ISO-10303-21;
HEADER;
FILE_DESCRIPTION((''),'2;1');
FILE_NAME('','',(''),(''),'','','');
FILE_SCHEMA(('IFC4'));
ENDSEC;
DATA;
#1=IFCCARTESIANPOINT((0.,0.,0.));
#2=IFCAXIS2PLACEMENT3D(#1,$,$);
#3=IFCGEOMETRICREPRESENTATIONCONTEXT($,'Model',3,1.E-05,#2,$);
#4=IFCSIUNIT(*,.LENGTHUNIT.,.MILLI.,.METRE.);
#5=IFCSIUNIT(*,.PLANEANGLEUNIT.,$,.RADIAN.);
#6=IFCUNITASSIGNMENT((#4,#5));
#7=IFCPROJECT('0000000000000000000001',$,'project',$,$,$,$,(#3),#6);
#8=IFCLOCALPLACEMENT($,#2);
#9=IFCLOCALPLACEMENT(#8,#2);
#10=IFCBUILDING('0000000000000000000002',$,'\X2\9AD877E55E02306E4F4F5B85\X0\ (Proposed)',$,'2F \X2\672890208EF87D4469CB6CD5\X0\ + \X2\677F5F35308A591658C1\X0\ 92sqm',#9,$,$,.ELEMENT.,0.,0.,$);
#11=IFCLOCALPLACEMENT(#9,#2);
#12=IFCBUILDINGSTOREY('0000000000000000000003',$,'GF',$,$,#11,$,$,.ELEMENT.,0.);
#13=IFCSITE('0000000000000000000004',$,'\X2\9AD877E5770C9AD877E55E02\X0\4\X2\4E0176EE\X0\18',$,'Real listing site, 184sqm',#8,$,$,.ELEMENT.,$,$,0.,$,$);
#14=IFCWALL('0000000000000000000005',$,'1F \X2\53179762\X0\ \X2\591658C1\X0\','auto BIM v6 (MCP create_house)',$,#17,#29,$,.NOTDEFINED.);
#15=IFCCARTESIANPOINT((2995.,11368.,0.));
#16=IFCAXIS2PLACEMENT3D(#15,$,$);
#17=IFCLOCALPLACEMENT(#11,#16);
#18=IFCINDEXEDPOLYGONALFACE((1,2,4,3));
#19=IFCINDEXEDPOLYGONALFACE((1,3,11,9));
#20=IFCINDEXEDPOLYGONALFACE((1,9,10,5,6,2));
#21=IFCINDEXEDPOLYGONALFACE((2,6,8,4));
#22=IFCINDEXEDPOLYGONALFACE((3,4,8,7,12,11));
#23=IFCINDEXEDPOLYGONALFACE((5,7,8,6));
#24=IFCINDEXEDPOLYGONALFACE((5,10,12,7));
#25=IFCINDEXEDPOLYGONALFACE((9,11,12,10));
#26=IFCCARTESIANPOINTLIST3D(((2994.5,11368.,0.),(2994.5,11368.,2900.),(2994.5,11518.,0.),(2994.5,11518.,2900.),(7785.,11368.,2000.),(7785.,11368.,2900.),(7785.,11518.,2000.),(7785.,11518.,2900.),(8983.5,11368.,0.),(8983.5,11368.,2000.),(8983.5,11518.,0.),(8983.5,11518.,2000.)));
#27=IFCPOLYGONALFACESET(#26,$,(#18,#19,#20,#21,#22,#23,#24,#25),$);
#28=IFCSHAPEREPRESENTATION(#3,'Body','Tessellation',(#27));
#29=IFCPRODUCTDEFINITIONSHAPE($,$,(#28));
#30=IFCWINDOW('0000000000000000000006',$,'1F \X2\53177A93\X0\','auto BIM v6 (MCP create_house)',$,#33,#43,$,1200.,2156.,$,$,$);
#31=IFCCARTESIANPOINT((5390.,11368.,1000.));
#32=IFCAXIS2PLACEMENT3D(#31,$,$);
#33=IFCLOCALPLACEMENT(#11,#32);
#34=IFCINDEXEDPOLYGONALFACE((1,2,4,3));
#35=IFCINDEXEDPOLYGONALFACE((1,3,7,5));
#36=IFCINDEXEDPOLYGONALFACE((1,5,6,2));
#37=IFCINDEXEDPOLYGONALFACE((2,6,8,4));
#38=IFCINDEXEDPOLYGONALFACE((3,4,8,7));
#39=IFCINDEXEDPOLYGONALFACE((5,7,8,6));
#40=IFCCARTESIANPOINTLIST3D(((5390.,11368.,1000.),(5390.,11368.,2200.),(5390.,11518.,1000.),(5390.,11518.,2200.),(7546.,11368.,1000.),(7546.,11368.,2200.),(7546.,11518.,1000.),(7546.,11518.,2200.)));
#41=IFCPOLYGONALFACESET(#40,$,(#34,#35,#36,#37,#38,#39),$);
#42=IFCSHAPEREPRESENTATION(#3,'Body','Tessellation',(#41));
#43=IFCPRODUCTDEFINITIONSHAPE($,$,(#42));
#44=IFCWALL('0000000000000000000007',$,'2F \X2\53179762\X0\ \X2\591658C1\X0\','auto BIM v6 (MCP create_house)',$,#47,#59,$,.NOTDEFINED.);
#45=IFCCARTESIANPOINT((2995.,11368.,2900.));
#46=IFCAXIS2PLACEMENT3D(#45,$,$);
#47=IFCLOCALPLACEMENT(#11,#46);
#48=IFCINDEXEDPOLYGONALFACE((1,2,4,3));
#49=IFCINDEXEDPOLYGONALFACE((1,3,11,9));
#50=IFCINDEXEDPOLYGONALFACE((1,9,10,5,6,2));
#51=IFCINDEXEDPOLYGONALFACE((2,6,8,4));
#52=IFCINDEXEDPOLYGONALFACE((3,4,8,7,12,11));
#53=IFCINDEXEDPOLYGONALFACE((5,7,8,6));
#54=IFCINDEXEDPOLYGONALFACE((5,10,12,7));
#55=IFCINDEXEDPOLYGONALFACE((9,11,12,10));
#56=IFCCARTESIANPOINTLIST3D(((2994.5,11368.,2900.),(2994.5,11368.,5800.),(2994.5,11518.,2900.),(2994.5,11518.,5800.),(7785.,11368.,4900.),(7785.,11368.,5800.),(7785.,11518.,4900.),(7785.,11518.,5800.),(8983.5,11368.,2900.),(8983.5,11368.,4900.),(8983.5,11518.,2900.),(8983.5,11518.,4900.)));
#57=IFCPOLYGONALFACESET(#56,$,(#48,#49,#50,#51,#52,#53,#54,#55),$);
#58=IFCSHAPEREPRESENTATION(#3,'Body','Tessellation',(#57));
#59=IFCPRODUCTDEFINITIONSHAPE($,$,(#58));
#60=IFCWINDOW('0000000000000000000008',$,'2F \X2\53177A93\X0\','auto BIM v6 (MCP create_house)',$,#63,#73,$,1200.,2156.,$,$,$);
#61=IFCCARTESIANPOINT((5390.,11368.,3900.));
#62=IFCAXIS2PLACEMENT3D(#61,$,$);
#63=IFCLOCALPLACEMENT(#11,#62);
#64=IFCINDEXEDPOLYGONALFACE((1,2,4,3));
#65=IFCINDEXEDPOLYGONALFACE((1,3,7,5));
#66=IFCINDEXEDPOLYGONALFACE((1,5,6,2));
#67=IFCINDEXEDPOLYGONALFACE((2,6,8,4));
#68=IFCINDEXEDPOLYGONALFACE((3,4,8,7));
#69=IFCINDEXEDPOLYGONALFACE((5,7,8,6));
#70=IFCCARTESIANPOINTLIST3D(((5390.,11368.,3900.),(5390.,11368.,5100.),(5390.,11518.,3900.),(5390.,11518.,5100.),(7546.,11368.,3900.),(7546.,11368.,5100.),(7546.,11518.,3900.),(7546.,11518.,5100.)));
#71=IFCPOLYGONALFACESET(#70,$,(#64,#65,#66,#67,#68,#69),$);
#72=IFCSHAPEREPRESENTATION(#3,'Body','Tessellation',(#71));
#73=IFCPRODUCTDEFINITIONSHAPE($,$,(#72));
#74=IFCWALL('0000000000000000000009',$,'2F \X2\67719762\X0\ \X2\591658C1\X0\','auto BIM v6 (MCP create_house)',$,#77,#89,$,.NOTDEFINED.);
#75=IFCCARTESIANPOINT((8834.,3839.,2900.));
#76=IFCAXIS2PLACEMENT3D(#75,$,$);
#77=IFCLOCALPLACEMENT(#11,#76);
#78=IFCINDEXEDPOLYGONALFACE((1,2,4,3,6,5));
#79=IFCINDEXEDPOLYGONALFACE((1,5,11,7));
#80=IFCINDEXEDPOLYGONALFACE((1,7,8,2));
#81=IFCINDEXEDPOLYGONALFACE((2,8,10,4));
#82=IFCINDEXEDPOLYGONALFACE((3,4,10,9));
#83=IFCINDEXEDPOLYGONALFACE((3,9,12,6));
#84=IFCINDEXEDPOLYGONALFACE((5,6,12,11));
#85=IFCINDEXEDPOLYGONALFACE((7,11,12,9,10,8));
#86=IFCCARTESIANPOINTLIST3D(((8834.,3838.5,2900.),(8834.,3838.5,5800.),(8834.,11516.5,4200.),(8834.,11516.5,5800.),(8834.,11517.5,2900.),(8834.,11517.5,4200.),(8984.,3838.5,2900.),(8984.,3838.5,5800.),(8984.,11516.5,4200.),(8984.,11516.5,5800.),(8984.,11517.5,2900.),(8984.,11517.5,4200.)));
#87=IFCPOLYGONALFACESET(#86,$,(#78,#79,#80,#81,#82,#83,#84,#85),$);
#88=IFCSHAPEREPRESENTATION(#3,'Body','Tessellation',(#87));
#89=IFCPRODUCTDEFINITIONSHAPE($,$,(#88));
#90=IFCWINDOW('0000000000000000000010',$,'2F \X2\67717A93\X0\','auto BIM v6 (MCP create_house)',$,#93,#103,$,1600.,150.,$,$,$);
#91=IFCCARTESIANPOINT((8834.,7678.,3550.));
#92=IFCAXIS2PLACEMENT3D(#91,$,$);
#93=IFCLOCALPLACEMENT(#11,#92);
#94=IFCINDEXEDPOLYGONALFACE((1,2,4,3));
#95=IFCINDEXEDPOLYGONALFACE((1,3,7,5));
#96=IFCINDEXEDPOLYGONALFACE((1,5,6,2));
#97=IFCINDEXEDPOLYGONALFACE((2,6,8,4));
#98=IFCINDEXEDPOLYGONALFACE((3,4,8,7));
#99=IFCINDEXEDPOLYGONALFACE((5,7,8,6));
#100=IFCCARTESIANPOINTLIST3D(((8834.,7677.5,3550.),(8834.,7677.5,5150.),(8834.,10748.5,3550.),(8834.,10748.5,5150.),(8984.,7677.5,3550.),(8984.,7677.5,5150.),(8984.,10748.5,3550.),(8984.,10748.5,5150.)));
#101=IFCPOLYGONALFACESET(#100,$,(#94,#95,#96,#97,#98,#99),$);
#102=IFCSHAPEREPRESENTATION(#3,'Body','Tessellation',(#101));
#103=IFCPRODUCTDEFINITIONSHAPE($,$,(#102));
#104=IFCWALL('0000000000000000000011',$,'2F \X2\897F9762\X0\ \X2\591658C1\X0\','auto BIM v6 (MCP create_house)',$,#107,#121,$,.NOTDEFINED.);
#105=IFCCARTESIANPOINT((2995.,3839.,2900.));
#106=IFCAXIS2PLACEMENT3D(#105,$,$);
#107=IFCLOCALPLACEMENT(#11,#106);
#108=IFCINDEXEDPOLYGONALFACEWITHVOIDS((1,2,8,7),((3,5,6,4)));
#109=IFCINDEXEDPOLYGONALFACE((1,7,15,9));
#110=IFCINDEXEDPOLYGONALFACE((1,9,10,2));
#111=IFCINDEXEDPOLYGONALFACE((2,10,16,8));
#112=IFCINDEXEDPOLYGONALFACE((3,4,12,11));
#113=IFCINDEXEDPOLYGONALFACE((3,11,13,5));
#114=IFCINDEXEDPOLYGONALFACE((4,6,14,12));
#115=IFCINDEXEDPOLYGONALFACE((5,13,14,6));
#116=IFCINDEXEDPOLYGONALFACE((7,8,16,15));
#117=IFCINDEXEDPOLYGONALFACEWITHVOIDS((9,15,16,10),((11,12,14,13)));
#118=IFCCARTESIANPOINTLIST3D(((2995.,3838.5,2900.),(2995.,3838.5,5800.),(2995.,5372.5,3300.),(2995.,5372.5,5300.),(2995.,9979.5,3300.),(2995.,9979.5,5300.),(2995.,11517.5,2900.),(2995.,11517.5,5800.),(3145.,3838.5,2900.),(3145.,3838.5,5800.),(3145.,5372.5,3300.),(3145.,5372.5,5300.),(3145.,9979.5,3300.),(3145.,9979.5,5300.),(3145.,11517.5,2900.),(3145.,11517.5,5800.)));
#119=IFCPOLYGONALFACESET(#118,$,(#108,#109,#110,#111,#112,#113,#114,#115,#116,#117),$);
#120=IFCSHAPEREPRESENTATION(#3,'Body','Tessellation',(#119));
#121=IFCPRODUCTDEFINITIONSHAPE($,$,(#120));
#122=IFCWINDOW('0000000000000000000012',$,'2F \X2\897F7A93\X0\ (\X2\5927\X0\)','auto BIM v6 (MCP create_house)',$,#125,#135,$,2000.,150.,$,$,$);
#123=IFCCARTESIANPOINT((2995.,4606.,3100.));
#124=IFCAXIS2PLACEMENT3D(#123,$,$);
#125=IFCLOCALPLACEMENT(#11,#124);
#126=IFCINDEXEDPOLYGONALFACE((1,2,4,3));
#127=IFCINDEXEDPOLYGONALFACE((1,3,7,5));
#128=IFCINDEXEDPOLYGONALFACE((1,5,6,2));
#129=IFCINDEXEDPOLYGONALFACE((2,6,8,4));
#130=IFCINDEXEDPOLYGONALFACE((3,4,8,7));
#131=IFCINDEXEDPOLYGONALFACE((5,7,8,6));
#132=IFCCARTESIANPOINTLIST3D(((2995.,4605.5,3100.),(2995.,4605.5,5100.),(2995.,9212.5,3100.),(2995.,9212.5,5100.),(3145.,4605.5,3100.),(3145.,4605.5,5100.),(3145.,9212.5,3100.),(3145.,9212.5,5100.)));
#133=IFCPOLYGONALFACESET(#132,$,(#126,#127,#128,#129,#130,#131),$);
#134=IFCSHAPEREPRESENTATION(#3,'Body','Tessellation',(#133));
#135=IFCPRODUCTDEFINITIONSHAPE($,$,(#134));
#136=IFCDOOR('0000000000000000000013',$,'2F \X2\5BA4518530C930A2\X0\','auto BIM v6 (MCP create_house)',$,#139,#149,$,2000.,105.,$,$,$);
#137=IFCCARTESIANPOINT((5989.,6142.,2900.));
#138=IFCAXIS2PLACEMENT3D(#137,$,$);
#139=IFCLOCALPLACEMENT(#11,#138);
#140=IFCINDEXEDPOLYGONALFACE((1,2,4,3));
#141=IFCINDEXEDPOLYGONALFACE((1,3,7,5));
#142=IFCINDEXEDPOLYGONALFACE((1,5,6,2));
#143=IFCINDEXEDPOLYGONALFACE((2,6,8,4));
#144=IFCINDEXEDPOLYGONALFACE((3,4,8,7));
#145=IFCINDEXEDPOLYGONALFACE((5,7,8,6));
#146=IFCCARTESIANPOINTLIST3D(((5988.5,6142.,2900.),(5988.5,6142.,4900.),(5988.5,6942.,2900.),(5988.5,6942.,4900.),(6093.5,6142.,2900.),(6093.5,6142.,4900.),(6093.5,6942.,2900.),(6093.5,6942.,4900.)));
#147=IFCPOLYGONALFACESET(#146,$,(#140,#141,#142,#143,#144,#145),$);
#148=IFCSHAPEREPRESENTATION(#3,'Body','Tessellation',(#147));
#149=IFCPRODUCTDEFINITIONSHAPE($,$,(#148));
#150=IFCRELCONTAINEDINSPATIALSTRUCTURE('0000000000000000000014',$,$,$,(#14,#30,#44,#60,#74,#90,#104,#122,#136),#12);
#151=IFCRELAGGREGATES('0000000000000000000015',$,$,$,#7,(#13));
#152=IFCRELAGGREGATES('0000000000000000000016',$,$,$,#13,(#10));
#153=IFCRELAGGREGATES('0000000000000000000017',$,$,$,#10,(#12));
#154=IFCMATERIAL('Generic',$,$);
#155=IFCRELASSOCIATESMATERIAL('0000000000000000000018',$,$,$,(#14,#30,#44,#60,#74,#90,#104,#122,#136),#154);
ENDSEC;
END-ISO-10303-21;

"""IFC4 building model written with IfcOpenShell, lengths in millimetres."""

from ifc_helpers import new_model, si_unit, frame, frame_2d, origin, place, context, project, spatial, rectangle, extrude, material, element, fill, save


model = new_model("IFC4")

# Units and contexts
model_context = context("Model", 3, precision=1e-05, world=origin())
ifc_project = project(units=[si_unit("LENGTHUNIT", "METRE", prefix="MILLI"), si_unit("PLANEANGLEUNIT", "RADIAN")], contexts=[model_context])

# Site, building, storey
site_placement = place(None, origin())
site = spatial("IfcSite", under=ifc_project, at=site_placement, Name="高知県高知市4丁目18", ObjectType="Real listing site, 184sqm", CompositionType="ELEMENT", RefElevation=0.0)
building_placement = place(site_placement, origin())
building = spatial("IfcBuilding", under=site, at=building_placement, Name="高知市の住宅 (Proposed)", ObjectType="2F 木造軸組構法 + 板張り外壁 92sqm", CompositionType="ELEMENT", ElevationOfRefHeight=0.0, ElevationOfTerrain=0.0)
storey_placement = place(building_placement, origin())
storey = spatial("IfcBuildingStorey", under=building, at=storey_placement, Name="GF", CompositionType="ELEMENT", Elevation=0.0)

# Wall, opening, window
ifc_material = material(Name="Generic")
wall_1_placement = place(storey_placement, frame((2995.0, 11368.0, 0.0)))
wall_1 = element("IfcWall", 1, at=wall_1_placement, inside=storey, material=ifc_material, Name="1F 北面 外壁", Description="auto BIM v6 (MCP create_house)", PredefinedType="NOTDEFINED", context=model_context, shape_type="SweptSolid", body=[
    extrude(rectangle(XDim=5989.0, YDim=150.0, at=frame_2d((2994.0, 75.0))), frame((2995.0, 11368.0, 0.0)), (0.0, 0.0, 1.0), 2900.0),
])
opening_1_placement = place(storey_placement, frame((5390.0, 11368.0, 1000.0)))
opening_1 = element("IfcOpeningElement", 2, at=opening_1_placement, cuts=wall_1, PredefinedType="NOTDEFINED", context=model_context, shape_type="SweptSolid", body=[
    extrude(rectangle(XDim=2156.0, YDim=150.0, at=frame_2d((1078.0, 75.0))), frame((5390.0, 11368.0, 1000.0)), (0.0, 0.0, 1.0), 1200.0),
])
window_1_placement = place(storey_placement, frame((5390.0, 11368.0, 1000.0)))
window_1 = element("IfcWindow", 3, at=window_1_placement, inside=storey, material=ifc_material, Name="1F 北窓", Description="auto BIM v6 (MCP create_house)", OverallHeight=1200.0, OverallWidth=2156.0, context=model_context, shape_type="SweptSolid", body=[
    extrude(rectangle(XDim=2156.0, YDim=150.0, at=frame_2d((1078.0, 75.0))), frame((5390.0, 11368.0, 1000.0)), (0.0, 0.0, 1.0), 1200.0),
])
fill(opening_1, window_1)

# Walls, openings, windows
wall_2_placement = place(storey_placement, frame((2995.0, 11368.0, 2900.0)))
wall_2 = element("IfcWall", 4, at=wall_2_placement, inside=storey, material=ifc_material, Name="2F 北面 外壁", Description="auto BIM v6 (MCP create_house)", PredefinedType="NOTDEFINED", context=model_context, shape_type="SweptSolid", body=[
    extrude(rectangle(XDim=5989.0, YDim=150.0, at=frame_2d((2994.0, 75.0))), frame((2995.0, 11368.0, 2900.0)), (0.0, 0.0, 1.0), 2900.0),
])
opening_2_placement = place(storey_placement, frame((5390.0, 11368.0, 3900.0)))
opening_2 = element("IfcOpeningElement", 5, at=opening_2_placement, cuts=wall_2, PredefinedType="NOTDEFINED", context=model_context, shape_type="SweptSolid", body=[
    extrude(rectangle(XDim=2156.0, YDim=150.0, at=frame_2d((1078.0, 75.0))), frame((5390.0, 11368.0, 3900.0)), (0.0, 0.0, 1.0), 1200.0),
])
window_2_placement = place(storey_placement, frame((5390.0, 11368.0, 3900.0)))
window_2 = element("IfcWindow", 6, at=window_2_placement, inside=storey, material=ifc_material, Name="2F 北窓", Description="auto BIM v6 (MCP create_house)", OverallHeight=1200.0, OverallWidth=2156.0, context=model_context, shape_type="SweptSolid", body=[
    extrude(rectangle(XDim=2156.0, YDim=150.0, at=frame_2d((1078.0, 75.0))), frame((5390.0, 11368.0, 3900.0)), (0.0, 0.0, 1.0), 1200.0),
])
fill(opening_2, window_2)
wall_3_placement = place(storey_placement, frame((8834.0, 3839.0, 2900.0)))
wall_3 = element("IfcWall", 7, at=wall_3_placement, inside=storey, material=ifc_material, Name="2F 東面 外壁", Description="auto BIM v6 (MCP create_house)", PredefinedType="NOTDEFINED", context=model_context, shape_type="SweptSolid", body=[
    extrude(rectangle(XDim=150.0, YDim=7679.0, at=frame_2d((75.0, 3839.0))), frame((8834.0, 3839.0, 2900.0)), (0.0, 0.0, 1.0), 2900.0),
])
opening_3_placement = place(storey_placement, frame((8834.0, 7678.0, 3550.0)))
opening_3 = element("IfcOpeningElement", 8, at=opening_3_placement, cuts=wall_3, PredefinedType="NOTDEFINED", context=model_context, shape_type="SweptSolid", body=[
    extrude(rectangle(XDim=150.0, YDim=3071.0, at=frame_2d((75.0, 1535.0))), frame((8834.0, 7678.0, 3550.0)), (0.0, 0.0, 1.0), 1600.0),
])
window_3_placement = place(storey_placement, frame((8834.0, 7678.0, 3550.0)))
window_3 = element("IfcWindow", 9, at=window_3_placement, inside=storey, material=ifc_material, Name="2F 東窓", Description="auto BIM v6 (MCP create_house)", OverallHeight=1600.0, OverallWidth=150.0, context=model_context, shape_type="SweptSolid", body=[
    extrude(rectangle(XDim=150.0, YDim=3071.0, at=frame_2d((75.0, 1535.0))), frame((8834.0, 7678.0, 3550.0)), (0.0, 0.0, 1.0), 1600.0),
])
fill(opening_3, window_3)
wall_4_placement = place(storey_placement, frame((2995.0, 3839.0, 2900.0)))
wall_4 = element("IfcWall", 10, at=wall_4_placement, inside=storey, material=ifc_material, Name="2F 西面 外壁", Description="auto BIM v6 (MCP create_house)", PredefinedType="NOTDEFINED", context=model_context, shape_type="SweptSolid", body=[
    extrude(rectangle(XDim=150.0, YDim=7679.0, at=frame_2d((75.0, 3839.0))), frame((2995.0, 3839.0, 2900.0)), (0.0, 0.0, 1.0), 2900.0),
])
opening_4_placement = place(storey_placement, frame((2995.0, 4606.0, 3100.0)))
opening_4 = element("IfcOpeningElement", 11, at=opening_4_placement, cuts=wall_4, PredefinedType="NOTDEFINED", context=model_context, shape_type="SweptSolid", body=[
    extrude(rectangle(XDim=150.0, YDim=4607.0, at=frame_2d((75.0, 2303.0))), frame((2995.0, 4606.0, 3100.0)), (0.0, 0.0, 1.0), 2000.0),
])
window_4_placement = place(storey_placement, frame((2995.0, 4606.0, 3100.0)))
window_4 = element("IfcWindow", 12, at=window_4_placement, inside=storey, material=ifc_material, Name="2F 西窓 (大)", Description="auto BIM v6 (MCP create_house)", OverallHeight=2000.0, OverallWidth=150.0, context=model_context, shape_type="SweptSolid", body=[
    extrude(rectangle(XDim=150.0, YDim=4607.0, at=frame_2d((75.0, 2303.0))), frame((2995.0, 4606.0, 3100.0)), (0.0, 0.0, 1.0), 2000.0),
])
fill(opening_4, window_4)

# Door
door_placement = place(storey_placement, frame((5989.0, 6142.0, 2900.0)))
element("IfcDoor", 13, at=door_placement, inside=storey, material=ifc_material, Name="2F 室内ドア", Description="auto BIM v6 (MCP create_house)", OverallHeight=2000.0, OverallWidth=105.0, context=model_context, shape_type="SweptSolid", body=[
    extrude(rectangle(XDim=105.0, YDim=800.0, at=frame_2d((52.0, 400.0))), frame((5989.0, 6142.0, 2900.0)), (0.0, 0.0, 1.0), 2000.0),
])

save(model, "model.ifc")
